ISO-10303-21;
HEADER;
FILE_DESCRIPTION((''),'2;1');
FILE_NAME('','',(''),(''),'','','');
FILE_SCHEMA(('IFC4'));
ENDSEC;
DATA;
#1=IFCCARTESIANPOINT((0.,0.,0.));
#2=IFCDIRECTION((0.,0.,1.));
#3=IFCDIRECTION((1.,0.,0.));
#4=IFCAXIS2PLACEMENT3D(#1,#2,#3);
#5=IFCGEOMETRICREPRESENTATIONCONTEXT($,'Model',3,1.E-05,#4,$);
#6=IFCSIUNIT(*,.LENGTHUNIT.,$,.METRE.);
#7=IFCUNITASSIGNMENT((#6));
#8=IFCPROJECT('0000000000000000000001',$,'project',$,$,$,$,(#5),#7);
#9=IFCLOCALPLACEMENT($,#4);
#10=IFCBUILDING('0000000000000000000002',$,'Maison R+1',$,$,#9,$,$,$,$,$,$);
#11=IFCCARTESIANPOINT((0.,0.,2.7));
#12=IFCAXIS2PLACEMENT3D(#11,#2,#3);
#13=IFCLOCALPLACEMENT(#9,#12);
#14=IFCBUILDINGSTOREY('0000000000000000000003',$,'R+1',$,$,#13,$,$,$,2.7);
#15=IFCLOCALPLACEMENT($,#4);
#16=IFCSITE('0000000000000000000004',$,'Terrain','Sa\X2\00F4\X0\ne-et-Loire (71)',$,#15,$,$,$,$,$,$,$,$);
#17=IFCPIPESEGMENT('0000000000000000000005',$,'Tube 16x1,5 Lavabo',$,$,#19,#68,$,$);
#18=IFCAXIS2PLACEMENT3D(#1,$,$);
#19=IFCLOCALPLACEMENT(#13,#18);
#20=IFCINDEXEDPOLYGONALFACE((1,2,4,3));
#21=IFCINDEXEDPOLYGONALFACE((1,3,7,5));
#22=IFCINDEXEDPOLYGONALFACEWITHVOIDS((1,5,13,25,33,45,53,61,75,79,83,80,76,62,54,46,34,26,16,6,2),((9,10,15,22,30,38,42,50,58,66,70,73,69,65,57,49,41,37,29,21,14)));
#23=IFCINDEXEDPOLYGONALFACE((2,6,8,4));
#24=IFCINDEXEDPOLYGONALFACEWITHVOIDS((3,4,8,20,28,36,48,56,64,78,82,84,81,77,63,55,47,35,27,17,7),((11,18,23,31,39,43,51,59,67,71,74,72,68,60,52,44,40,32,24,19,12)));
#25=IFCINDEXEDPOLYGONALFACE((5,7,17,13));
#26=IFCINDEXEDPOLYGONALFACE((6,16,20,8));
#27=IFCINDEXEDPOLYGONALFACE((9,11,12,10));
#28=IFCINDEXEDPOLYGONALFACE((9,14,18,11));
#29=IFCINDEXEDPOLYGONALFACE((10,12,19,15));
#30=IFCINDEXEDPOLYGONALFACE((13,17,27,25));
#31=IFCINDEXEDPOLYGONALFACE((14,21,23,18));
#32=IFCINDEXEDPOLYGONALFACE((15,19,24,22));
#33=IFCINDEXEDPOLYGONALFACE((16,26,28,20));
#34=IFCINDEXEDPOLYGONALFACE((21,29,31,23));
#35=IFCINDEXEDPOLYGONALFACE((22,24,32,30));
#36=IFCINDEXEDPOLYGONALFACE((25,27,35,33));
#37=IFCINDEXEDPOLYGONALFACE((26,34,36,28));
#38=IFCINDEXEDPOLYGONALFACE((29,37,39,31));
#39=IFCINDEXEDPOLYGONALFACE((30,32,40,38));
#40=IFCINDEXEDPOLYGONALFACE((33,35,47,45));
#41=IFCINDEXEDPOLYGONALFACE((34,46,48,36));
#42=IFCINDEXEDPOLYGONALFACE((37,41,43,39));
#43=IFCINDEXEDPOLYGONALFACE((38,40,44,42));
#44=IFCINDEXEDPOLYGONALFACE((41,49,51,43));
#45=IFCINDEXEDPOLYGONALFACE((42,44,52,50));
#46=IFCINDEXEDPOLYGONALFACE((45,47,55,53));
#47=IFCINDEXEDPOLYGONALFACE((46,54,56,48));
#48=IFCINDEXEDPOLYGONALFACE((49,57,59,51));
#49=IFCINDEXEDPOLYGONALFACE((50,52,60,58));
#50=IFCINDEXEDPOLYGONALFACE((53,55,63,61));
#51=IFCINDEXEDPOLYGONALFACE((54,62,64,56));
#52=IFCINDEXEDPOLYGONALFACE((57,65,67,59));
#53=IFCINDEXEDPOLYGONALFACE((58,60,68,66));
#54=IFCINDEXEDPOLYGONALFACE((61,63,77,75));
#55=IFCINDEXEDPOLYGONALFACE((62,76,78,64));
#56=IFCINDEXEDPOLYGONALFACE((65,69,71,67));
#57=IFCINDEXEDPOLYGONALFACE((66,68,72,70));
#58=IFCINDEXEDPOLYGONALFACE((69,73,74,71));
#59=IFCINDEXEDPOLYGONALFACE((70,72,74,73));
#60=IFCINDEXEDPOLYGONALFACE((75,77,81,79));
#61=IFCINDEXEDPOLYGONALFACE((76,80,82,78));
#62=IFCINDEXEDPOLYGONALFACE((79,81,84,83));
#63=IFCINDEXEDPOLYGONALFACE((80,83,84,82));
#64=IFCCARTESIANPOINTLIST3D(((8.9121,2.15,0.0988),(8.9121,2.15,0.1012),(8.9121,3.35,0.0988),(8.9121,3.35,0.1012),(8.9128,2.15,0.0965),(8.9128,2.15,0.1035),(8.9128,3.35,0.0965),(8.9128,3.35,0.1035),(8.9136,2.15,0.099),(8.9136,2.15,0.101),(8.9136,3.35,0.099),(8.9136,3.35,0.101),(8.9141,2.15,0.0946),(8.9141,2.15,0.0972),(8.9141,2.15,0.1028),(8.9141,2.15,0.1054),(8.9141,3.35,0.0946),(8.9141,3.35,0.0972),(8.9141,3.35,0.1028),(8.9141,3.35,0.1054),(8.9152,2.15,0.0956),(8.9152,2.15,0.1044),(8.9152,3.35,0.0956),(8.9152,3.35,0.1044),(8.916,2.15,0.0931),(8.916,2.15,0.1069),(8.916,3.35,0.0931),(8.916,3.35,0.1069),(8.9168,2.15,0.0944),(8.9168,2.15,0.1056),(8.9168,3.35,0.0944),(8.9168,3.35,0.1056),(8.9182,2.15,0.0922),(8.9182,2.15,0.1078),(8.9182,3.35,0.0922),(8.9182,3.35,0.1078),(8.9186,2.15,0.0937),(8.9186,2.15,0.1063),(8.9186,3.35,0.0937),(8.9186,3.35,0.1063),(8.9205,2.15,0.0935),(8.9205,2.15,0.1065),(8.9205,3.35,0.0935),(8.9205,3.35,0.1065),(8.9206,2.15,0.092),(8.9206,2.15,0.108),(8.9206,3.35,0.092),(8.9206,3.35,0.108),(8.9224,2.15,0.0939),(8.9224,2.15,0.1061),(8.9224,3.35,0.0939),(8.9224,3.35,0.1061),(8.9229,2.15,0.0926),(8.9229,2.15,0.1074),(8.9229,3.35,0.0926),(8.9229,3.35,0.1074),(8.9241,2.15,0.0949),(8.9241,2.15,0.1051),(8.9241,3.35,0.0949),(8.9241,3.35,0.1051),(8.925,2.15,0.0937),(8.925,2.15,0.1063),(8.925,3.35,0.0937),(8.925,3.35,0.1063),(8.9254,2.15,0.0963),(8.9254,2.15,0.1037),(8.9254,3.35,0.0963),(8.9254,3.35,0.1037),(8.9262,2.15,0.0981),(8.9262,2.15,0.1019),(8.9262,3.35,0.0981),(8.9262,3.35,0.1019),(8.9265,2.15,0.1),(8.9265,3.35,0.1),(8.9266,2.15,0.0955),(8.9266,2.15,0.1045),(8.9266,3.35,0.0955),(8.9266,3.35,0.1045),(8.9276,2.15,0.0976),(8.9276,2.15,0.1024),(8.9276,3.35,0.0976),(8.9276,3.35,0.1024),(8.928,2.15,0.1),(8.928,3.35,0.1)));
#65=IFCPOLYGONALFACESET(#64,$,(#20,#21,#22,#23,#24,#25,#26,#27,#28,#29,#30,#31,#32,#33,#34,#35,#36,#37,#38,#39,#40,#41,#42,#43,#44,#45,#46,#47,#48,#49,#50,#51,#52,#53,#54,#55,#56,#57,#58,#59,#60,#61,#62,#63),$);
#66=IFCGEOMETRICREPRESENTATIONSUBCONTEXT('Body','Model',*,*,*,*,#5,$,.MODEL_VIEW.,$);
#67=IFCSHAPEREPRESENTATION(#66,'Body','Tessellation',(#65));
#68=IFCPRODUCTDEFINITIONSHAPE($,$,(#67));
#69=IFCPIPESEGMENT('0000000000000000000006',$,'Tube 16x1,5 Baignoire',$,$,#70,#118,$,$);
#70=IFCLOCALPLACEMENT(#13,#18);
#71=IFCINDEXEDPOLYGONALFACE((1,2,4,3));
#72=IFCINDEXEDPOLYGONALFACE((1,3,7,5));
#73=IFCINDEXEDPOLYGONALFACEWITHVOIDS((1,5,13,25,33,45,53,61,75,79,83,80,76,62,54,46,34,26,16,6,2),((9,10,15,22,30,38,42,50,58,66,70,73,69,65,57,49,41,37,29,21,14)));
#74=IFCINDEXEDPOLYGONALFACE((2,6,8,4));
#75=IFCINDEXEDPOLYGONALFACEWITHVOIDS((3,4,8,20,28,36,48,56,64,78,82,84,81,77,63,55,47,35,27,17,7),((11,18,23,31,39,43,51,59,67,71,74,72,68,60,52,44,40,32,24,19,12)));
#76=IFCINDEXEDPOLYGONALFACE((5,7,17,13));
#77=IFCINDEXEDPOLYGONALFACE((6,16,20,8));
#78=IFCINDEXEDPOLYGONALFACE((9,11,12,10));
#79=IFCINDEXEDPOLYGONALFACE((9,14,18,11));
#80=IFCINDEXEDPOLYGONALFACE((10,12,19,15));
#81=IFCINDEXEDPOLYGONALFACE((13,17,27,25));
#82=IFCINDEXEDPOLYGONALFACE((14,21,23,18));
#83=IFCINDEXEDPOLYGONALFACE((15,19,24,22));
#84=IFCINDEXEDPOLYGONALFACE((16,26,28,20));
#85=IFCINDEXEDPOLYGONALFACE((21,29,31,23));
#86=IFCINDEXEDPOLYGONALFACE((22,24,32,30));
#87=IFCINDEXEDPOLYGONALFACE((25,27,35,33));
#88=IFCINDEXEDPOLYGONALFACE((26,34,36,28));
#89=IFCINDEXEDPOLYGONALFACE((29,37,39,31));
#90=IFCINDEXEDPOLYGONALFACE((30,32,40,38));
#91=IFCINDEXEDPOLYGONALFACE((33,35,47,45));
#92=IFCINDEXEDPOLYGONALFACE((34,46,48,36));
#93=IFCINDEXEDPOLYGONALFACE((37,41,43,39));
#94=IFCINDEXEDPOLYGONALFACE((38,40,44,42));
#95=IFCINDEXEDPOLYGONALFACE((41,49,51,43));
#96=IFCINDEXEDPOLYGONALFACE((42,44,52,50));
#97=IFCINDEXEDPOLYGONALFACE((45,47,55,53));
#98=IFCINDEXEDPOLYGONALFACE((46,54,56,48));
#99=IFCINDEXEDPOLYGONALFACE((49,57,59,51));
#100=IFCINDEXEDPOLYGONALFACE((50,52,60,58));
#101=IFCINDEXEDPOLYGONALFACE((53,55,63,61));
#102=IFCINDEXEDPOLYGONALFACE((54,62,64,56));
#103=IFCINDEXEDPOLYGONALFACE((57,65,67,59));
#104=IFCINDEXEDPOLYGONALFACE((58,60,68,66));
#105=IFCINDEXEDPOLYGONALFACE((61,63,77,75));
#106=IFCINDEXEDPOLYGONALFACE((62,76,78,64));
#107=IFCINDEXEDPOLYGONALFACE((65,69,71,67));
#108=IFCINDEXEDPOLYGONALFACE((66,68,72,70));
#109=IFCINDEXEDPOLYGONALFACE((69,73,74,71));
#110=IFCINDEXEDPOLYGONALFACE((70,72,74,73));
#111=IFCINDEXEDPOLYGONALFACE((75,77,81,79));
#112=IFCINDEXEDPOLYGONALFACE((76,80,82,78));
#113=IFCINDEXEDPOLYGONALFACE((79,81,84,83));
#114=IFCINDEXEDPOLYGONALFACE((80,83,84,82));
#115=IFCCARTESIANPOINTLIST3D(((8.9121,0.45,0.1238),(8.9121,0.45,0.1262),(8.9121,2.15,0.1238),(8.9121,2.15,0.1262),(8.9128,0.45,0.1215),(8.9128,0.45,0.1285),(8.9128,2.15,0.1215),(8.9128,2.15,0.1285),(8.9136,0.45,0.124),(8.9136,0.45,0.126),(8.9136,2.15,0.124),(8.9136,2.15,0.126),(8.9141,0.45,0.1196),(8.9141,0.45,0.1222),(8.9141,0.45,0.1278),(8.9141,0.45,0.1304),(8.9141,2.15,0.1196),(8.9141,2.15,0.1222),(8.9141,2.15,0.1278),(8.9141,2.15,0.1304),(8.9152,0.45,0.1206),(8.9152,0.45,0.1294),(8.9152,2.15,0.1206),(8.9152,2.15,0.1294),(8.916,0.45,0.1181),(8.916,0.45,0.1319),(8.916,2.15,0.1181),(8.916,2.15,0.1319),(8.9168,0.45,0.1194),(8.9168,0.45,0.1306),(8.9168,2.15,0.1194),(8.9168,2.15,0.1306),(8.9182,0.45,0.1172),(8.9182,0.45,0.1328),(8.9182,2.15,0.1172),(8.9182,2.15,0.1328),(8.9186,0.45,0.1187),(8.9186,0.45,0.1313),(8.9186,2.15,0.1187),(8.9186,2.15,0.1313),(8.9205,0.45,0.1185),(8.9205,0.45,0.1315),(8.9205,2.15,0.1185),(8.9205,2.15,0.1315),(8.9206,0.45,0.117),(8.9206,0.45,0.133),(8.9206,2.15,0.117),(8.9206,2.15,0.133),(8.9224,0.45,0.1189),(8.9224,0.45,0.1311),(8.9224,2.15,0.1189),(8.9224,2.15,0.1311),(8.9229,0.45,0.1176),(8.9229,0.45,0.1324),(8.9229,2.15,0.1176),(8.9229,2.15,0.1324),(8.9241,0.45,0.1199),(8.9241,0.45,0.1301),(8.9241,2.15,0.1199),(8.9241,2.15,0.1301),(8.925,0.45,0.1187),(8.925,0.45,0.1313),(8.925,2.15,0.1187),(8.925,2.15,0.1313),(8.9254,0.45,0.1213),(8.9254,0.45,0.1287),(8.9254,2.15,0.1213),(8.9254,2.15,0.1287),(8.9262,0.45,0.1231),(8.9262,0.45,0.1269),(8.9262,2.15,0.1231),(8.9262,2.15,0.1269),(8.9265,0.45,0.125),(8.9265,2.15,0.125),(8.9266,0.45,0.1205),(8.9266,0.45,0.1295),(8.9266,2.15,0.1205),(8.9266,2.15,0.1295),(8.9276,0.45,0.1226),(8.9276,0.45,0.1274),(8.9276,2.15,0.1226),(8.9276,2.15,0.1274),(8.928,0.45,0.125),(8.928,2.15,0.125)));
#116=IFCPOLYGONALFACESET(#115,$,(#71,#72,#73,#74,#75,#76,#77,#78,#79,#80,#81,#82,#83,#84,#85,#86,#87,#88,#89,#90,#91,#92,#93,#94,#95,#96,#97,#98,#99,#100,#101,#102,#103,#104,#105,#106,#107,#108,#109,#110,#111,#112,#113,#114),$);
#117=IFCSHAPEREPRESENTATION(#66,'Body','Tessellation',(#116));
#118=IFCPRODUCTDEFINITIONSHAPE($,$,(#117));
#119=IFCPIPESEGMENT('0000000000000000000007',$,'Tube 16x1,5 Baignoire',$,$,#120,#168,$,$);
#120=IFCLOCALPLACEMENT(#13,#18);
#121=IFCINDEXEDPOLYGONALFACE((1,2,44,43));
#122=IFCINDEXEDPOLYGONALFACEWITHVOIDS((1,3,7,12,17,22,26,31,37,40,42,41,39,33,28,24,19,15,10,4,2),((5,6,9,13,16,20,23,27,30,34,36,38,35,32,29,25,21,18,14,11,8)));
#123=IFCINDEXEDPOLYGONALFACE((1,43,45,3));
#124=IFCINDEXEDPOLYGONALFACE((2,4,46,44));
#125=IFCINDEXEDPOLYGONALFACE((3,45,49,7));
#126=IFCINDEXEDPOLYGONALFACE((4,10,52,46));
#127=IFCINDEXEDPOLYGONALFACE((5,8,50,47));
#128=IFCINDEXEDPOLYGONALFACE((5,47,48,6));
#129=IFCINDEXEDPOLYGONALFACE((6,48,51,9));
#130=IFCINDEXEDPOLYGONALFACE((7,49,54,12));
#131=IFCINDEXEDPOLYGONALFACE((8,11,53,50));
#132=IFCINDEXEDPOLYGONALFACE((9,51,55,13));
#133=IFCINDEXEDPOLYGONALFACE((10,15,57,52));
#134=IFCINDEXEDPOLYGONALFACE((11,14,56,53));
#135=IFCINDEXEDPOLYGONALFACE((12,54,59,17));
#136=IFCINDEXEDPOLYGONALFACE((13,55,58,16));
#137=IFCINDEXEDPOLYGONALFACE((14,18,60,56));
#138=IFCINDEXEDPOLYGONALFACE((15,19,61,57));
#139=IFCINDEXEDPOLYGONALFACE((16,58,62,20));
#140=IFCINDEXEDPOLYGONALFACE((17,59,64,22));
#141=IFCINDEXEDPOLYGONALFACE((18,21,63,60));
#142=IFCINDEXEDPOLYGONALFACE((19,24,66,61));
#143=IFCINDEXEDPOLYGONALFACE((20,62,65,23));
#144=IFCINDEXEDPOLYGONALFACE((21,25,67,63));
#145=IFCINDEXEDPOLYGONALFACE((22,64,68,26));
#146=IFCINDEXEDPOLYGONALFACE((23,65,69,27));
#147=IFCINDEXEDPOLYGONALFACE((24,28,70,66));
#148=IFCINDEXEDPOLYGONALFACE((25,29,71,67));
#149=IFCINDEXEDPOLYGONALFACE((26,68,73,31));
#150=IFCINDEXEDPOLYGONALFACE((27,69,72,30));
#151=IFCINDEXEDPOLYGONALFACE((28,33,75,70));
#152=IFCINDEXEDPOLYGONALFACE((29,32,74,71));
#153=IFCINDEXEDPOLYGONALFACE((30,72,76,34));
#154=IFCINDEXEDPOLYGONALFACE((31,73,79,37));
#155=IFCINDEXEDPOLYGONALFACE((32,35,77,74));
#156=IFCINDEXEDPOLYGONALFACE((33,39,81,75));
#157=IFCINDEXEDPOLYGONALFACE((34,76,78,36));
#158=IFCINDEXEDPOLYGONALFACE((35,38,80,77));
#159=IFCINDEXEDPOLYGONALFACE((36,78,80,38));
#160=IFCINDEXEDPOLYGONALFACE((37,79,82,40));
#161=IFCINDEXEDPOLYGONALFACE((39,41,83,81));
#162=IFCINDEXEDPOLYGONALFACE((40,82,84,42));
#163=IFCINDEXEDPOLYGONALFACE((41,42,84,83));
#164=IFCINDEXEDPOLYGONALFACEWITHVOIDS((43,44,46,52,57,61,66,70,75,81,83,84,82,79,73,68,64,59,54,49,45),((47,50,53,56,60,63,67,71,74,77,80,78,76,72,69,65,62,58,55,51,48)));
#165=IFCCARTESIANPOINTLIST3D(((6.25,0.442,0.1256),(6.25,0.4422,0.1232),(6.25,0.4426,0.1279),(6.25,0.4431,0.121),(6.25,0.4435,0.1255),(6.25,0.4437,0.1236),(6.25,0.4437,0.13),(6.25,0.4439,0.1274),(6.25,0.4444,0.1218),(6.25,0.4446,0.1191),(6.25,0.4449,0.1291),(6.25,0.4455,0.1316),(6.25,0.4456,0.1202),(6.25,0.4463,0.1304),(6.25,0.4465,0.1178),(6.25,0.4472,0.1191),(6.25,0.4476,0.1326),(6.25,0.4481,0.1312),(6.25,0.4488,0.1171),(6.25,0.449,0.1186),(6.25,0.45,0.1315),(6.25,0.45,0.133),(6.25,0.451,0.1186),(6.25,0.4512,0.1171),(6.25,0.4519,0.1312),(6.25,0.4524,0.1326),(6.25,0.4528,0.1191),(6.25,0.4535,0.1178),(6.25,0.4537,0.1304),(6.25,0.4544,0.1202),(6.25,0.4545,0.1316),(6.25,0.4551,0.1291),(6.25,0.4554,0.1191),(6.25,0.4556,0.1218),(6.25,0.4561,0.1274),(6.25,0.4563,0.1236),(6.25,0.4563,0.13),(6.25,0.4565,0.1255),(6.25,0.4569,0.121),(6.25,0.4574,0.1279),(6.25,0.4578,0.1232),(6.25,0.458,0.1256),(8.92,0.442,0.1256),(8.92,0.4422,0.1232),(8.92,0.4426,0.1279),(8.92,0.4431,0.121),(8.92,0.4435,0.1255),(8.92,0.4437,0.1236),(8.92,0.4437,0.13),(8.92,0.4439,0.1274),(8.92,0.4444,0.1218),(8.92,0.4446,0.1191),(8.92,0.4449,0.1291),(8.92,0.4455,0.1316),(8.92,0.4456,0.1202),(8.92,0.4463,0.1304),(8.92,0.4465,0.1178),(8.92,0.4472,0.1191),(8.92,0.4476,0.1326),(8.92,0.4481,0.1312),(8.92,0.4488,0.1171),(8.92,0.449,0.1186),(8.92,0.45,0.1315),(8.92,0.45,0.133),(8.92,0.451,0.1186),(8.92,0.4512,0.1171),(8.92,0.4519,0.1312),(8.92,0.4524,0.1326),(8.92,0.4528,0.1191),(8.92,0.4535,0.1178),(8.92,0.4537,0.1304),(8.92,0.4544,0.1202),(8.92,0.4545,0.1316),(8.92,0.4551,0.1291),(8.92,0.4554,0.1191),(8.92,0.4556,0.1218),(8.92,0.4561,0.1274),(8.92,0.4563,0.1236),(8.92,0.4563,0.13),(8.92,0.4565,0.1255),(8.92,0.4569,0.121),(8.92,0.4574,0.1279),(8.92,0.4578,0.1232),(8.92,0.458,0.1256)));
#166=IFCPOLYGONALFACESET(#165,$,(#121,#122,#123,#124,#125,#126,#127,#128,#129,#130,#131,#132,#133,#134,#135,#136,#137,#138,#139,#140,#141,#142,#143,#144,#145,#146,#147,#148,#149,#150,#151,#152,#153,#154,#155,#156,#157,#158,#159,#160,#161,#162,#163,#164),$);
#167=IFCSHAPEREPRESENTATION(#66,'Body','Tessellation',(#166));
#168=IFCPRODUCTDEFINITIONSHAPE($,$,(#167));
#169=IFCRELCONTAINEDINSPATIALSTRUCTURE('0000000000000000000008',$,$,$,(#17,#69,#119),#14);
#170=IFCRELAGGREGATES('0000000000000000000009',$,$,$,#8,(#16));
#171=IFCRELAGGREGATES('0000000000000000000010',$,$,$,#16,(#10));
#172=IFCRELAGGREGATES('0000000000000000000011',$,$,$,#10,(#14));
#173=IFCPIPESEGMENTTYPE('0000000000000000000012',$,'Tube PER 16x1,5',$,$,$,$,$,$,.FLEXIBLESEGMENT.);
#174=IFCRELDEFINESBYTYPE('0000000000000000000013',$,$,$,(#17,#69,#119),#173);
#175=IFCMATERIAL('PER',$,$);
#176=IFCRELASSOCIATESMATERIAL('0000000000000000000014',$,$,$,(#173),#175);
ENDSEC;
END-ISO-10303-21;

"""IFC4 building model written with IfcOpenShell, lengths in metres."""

from ifc_helpers import new_model, si_unit, frame, origin_with_axes, place, context, subcontext, project, spatial, hollow_circle, extrude, material, type_object, element, save


model = new_model("IFC4")

# Units and contexts
model_context = context("Model", 3, precision=1e-05, world=origin_with_axes())
body_context = subcontext(model_context, "Body", "Model", "MODEL_VIEW")
ifc_project = project(units=[si_unit("LENGTHUNIT", "METRE")], contexts=[model_context])

# Site, building, storey
site_placement = place(None, origin_with_axes())
site = spatial("IfcSite", under=ifc_project, at=site_placement, Name="Terrain", Description="Saône-et-Loire (71)")
building_placement = place(None, origin_with_axes())
building = spatial("IfcBuilding", under=site, at=building_placement, Name="Maison R+1")
storey_placement = place(building_placement, frame((0.0, 0.0, 2.7), z_axis=(0.0, 0.0, 1.0), x_axis=(1.0, 0.0, 0.0)))
storey = spatial("IfcBuildingStorey", under=building, at=storey_placement, Name="R+1", Elevation=2.7)

# Pipe segments
ifc_material_1 = material(Name="PER")
pipe_segment_type_1 = type_object("IfcPipeSegmentType", Name="Tube PER 16x1,5", PredefinedType="FLEXIBLESEGMENT", material=ifc_material_1)
pipe_segment_1_placement = place(storey_placement, frame((8.92, 2.15, 0.1), z_axis=(0.0, 1.0, 0.0), x_axis=(1.0, 0.0, 0.0)))
element("IfcPipeSegment", 1, at=pipe_segment_1_placement, inside=storey, type_object=pipe_segment_type_1, Name="Tube 16x1,5 Lavabo", context=body_context, shape_type="SweptSolid", body=[
    extrude(hollow_circle(Radius=0.008, WallThickness=0.0015), origin_with_axes(), (0.0, 0.0, 1.0), 1.2),
])
pipe_segment_2_placement = place(storey_placement, frame((8.92, 2.15, 0.125), z_axis=(0.0, -1.0, 0.0), x_axis=(1.0, 0.0, 0.0)))
element("IfcPipeSegment", 2, at=pipe_segment_2_placement, inside=storey, type_object=pipe_segment_type_1, Name="Tube 16x1,5 Baignoire", context=body_context, shape_type="SweptSolid", body=[
    extrude(hollow_circle(Radius=0.008, WallThickness=0.0015), origin_with_axes(), (0.0, 0.0, 1.0), 1.7),
])
pipe_segment_3_placement = place(storey_placement, frame((8.92, 0.45, 0.125), z_axis=(-1.0, 0.0, 0.0), x_axis=(0.0, 0.0, 1.0)))
element("IfcPipeSegment", 3, at=pipe_segment_3_placement, inside=storey, type_object=pipe_segment_type_1, Name="Tube 16x1,5 Baignoire", context=body_context, shape_type="SweptSolid", body=[
    extrude(hollow_circle(Radius=0.008, WallThickness=0.0015), origin_with_axes(), (0.0, 0.0, 1.0), 2.67),
])

save(model, "model.ifc")
